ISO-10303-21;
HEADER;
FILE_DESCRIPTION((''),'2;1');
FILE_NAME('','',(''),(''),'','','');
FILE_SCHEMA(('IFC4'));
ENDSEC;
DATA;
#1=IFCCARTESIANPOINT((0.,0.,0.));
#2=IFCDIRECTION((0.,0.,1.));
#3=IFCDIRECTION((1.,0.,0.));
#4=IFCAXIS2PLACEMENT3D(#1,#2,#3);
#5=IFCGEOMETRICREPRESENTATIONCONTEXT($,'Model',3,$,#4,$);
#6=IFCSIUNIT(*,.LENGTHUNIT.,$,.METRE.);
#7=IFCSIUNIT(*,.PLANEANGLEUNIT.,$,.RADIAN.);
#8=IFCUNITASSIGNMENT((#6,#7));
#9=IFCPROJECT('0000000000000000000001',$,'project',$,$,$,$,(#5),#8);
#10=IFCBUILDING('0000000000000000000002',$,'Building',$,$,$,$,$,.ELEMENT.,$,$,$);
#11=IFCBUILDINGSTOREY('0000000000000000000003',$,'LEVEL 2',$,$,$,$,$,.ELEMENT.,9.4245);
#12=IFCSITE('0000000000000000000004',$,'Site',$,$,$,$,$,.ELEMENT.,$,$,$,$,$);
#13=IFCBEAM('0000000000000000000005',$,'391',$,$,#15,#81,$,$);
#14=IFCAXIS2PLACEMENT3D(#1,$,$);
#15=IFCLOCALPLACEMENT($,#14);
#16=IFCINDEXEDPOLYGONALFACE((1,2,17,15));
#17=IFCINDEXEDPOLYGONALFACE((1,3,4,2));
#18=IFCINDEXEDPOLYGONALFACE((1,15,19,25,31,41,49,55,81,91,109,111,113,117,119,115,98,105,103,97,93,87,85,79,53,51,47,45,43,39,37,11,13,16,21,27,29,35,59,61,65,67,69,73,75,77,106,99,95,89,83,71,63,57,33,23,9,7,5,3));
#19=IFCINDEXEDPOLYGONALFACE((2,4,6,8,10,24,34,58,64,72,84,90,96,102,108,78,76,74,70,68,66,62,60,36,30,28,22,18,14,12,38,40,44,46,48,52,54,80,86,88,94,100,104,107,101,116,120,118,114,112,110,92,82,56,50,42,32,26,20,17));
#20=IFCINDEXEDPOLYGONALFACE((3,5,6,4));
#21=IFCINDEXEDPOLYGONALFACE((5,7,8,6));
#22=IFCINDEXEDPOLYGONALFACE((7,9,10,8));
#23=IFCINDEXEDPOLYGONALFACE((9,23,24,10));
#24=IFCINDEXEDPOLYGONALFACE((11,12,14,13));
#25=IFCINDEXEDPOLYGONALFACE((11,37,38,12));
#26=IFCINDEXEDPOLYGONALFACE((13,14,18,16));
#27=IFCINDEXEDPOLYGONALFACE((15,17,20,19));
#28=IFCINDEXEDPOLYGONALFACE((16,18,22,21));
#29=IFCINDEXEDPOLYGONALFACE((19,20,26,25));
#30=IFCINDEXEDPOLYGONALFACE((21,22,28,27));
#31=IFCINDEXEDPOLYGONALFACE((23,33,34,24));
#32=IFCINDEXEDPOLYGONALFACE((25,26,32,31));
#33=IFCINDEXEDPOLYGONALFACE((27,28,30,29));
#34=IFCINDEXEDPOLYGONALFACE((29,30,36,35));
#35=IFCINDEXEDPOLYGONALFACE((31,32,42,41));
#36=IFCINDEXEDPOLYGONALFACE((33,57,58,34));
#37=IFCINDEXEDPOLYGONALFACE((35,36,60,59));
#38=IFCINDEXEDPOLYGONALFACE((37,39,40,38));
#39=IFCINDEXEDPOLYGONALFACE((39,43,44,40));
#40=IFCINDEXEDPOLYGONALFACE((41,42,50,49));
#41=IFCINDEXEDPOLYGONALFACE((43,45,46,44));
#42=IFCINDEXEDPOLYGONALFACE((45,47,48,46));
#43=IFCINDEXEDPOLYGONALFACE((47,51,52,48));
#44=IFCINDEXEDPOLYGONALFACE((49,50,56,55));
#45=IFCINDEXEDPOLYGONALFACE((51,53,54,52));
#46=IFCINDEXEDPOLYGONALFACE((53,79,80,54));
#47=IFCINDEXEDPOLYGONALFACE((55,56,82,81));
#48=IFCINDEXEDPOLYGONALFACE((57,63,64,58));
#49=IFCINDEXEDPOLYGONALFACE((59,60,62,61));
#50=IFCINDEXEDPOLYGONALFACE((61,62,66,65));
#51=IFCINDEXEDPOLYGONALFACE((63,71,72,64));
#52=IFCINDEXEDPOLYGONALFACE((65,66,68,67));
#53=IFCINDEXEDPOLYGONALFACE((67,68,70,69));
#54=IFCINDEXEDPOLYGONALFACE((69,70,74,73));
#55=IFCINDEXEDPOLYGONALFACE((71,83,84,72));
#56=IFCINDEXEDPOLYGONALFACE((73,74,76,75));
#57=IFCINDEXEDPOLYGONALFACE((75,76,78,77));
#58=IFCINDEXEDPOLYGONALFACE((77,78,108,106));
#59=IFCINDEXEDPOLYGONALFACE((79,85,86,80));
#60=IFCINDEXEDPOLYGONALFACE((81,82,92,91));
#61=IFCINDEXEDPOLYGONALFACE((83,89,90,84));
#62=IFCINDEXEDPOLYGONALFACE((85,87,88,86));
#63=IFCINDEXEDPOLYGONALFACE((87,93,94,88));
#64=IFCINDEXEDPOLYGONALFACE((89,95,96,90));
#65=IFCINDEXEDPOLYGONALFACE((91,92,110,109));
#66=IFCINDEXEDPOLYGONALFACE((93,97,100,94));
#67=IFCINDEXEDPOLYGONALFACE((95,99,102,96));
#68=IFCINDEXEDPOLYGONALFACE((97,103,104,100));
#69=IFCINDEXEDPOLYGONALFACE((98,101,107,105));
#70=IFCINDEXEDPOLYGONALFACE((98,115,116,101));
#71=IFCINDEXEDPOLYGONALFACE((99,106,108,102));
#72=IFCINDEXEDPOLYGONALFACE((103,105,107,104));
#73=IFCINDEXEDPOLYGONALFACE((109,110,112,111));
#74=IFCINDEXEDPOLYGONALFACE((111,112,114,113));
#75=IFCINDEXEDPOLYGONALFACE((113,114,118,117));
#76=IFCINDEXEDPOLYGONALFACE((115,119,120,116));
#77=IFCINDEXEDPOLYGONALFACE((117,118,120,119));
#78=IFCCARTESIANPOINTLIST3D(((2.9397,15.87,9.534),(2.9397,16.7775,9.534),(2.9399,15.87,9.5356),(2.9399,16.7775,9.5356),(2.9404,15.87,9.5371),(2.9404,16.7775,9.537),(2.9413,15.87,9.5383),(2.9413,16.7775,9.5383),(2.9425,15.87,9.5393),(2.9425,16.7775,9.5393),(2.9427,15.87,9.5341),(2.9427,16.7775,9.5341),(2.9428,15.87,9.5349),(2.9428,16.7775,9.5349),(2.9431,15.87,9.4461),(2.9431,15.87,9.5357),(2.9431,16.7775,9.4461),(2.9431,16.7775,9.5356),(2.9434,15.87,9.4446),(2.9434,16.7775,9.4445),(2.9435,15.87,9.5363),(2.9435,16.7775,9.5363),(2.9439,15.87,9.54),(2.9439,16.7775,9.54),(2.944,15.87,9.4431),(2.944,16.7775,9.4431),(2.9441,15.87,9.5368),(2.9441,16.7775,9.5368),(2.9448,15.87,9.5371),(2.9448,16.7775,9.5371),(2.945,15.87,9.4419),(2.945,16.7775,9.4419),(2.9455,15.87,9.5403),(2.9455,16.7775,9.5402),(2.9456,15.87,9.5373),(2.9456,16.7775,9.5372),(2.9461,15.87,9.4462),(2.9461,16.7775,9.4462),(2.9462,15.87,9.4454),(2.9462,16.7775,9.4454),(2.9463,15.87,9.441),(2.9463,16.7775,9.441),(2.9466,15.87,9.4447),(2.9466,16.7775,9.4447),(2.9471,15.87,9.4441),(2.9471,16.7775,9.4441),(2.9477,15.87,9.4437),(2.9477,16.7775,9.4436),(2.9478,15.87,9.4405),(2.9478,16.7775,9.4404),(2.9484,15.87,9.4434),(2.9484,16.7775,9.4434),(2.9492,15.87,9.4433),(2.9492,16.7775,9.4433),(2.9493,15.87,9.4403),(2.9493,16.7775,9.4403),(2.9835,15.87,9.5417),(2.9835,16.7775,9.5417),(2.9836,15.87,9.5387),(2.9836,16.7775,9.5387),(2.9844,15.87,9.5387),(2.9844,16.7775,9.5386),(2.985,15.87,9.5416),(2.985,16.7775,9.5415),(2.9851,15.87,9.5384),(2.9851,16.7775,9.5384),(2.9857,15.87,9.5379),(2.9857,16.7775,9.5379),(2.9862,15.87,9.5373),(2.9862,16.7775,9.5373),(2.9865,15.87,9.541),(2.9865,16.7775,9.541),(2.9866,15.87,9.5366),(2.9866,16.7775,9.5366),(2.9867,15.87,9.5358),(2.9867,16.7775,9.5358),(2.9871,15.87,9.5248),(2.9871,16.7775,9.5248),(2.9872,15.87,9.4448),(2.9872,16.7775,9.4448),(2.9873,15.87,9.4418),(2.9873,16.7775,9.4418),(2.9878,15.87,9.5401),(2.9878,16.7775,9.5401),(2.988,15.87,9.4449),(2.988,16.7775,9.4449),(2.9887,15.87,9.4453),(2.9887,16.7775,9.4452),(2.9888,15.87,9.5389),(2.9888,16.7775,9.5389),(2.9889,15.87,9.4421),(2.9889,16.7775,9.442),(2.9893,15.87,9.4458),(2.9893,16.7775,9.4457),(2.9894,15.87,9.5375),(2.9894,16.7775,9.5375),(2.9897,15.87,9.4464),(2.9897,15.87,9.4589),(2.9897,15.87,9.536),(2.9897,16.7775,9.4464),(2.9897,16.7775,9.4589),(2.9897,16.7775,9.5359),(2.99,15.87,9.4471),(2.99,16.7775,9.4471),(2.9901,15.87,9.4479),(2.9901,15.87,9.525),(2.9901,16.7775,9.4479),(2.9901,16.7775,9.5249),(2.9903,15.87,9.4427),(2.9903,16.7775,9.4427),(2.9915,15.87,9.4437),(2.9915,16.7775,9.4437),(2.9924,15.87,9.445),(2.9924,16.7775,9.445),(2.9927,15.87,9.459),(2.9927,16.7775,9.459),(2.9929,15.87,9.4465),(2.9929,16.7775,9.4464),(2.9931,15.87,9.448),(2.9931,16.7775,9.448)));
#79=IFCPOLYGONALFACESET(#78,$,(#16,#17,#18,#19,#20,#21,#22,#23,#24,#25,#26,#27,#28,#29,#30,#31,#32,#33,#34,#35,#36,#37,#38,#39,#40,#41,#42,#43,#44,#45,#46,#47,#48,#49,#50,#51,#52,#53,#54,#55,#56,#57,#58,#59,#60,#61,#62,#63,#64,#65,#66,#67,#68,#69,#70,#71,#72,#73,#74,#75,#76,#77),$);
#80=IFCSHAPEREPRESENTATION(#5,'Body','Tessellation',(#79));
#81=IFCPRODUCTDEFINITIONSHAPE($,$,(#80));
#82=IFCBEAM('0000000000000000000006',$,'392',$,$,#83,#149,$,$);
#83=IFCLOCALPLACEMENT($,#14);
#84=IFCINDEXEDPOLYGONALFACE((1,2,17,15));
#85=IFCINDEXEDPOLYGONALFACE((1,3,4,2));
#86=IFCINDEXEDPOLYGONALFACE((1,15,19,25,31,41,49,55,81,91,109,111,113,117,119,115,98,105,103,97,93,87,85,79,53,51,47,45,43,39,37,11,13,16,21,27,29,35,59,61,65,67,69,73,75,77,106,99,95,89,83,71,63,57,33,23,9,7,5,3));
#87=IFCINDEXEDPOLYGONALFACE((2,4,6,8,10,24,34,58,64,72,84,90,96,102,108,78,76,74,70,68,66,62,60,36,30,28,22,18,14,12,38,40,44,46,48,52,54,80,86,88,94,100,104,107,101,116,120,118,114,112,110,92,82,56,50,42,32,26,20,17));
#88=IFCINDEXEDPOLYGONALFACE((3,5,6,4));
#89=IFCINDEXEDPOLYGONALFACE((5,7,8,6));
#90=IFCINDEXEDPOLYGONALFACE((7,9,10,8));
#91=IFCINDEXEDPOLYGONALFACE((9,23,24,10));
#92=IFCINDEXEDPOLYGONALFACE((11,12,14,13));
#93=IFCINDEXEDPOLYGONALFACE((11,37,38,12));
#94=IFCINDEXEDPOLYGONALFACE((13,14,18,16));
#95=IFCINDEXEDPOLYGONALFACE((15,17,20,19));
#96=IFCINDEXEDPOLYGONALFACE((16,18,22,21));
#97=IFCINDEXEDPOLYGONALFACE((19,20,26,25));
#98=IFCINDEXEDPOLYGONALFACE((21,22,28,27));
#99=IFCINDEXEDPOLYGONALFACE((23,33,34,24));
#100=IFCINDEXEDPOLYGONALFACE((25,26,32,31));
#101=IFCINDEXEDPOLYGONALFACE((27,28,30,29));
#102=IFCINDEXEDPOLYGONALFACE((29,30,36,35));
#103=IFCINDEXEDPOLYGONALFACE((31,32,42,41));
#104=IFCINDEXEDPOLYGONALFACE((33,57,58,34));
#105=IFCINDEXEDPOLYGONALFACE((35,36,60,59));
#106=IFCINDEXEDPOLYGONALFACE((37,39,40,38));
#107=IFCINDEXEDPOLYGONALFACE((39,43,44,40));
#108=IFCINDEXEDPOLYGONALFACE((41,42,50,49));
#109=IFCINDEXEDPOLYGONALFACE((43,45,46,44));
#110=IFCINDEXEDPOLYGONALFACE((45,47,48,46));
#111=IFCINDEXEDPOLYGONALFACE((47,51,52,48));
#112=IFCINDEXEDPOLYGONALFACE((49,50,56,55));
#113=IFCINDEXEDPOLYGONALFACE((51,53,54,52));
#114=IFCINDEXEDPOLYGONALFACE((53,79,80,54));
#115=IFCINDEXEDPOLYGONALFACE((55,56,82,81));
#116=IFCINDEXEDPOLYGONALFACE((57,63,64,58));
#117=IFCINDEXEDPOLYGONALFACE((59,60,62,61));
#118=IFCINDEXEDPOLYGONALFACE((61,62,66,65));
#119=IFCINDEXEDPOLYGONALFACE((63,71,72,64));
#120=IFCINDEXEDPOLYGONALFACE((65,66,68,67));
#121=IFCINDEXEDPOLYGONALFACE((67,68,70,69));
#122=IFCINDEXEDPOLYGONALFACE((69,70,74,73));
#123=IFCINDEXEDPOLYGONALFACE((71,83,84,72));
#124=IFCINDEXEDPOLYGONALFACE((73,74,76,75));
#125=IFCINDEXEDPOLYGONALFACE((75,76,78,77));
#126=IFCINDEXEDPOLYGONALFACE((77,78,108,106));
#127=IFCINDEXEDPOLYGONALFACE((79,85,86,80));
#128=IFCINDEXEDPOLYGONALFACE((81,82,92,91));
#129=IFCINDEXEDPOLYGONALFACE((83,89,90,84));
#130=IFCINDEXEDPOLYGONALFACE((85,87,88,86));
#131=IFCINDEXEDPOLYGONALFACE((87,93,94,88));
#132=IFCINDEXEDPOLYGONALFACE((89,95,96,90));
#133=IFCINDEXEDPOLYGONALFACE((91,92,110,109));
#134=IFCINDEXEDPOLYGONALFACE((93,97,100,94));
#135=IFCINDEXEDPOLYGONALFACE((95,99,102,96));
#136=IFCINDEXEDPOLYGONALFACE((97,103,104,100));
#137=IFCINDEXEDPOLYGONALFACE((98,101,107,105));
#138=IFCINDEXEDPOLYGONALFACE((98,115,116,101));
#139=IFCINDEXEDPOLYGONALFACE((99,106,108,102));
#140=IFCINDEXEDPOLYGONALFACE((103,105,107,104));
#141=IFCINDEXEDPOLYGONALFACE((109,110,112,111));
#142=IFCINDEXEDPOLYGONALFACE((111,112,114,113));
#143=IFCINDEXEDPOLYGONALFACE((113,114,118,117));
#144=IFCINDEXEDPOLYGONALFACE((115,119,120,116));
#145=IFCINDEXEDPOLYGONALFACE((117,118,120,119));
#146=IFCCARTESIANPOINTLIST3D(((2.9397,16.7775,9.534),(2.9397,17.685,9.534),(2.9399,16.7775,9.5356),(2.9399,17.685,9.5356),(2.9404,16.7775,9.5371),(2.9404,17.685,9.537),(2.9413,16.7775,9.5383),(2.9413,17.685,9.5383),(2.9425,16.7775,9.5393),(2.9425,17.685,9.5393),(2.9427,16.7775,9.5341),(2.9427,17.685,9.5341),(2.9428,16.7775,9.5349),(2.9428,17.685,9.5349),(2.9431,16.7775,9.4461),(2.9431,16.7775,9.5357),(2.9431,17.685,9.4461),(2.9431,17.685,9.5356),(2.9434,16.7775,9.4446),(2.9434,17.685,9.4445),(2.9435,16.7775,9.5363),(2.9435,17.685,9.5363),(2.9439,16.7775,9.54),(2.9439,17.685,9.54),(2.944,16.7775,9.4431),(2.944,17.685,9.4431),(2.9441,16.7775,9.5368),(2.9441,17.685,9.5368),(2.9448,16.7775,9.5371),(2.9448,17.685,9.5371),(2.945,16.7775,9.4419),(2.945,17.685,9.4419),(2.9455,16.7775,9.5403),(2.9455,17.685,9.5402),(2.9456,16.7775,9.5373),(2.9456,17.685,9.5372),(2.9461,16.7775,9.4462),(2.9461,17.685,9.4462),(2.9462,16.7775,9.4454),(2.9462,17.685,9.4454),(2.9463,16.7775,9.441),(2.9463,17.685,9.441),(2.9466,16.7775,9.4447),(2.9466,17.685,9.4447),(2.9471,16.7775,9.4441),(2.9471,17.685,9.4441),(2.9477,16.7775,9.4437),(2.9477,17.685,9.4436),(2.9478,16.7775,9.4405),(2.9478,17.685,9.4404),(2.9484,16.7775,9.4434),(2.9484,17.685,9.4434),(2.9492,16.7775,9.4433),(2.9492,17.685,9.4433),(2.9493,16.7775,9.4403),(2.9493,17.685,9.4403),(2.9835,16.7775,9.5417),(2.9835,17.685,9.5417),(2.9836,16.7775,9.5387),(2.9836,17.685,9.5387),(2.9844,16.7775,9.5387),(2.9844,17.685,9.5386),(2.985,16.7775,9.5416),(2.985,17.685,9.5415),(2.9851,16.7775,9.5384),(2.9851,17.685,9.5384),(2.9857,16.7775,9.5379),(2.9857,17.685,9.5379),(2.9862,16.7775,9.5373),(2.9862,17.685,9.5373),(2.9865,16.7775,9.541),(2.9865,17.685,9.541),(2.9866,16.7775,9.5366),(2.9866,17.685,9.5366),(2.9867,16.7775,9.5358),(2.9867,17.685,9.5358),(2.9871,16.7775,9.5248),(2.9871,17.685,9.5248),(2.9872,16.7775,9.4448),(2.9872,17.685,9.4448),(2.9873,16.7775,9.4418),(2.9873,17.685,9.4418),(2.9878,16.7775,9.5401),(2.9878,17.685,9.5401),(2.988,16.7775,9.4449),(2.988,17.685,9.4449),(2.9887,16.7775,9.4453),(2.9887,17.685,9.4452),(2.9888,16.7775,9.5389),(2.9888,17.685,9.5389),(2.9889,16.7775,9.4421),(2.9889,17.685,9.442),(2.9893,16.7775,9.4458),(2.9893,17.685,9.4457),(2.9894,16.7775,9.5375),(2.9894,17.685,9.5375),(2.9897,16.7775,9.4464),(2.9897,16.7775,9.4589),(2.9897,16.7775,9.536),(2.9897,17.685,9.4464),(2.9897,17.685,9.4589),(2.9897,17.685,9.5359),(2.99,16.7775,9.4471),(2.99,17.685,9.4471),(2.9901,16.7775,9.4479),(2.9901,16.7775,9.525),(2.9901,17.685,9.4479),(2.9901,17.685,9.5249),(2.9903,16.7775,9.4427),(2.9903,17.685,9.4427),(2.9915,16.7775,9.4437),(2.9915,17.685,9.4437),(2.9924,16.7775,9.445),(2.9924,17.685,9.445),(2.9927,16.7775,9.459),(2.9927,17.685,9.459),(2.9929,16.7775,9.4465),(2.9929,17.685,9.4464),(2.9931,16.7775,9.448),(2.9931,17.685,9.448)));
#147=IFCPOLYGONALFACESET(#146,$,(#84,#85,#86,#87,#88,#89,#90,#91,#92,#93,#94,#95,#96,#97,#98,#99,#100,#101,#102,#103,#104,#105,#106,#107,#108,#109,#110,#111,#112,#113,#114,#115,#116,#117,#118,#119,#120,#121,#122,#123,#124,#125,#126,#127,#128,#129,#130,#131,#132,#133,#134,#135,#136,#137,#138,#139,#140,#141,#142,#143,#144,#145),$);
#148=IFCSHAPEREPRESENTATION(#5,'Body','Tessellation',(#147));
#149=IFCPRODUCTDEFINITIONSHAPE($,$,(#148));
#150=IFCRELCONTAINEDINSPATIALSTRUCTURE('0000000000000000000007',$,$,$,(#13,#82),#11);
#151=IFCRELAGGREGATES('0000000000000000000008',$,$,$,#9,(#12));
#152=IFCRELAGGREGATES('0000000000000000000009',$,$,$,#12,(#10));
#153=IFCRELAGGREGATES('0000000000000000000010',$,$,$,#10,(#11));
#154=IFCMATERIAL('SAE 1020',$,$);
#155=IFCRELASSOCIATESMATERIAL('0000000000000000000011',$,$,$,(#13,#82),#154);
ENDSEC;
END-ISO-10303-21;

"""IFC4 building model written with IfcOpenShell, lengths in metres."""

from ifc_helpers import new_model, si_unit, frame, origin_with_axes, origin_2d_with_axis, place, context, project, spatial, c_section, extrude, material, material_profile, profile_set, profile_usage, element, save


model = new_model("IFC4")

# Units and contexts
model_context = context("Model", 3, world=origin_with_axes())
ifc_project = project(units=[si_unit("LENGTHUNIT", "METRE"), si_unit("PLANEANGLEUNIT", "RADIAN")], contexts=[model_context])

# Site, building, storey
site = spatial("IfcSite", under=ifc_project, Name="Site", CompositionType="ELEMENT")
building = spatial("IfcBuilding", under=site, Name="Building", CompositionType="ELEMENT")
storey = spatial("IfcBuildingStorey", under=building, Name="LEVEL 2", CompositionType="ELEMENT", Elevation=9.4245)

# Beams
ifc_material = material(Name="SAE 1020")
ifc_material_profile_1 = material_profile(ifc_material, c_section(Depth=0.1, Width=0.05, WallThickness=0.003, Girth=0.017, InternalFilletRadius=0.003, at=origin_2d_with_axis()))
ifc_profile_set_1 = profile_set([ifc_material_profile_1])
ifc_profile_usage_1 = profile_usage(ifc_profile_set_1, cardinal=10)
beam_1_placement = place(None, frame((2.9664, 15.87, 9.491), z_axis=(0.0, 1.0, -0.00003), x_axis=(0.999256, 0.000001, 0.038562)))
element("IfcBeam", 1, at=beam_1_placement, inside=storey, material=ifc_profile_usage_1, Name="391", context=model_context, shape_type="SweptSolid", body=[
    extrude(c_section(Depth=0.1, Width=0.05, WallThickness=0.003, Girth=0.017, InternalFilletRadius=0.003, at=origin_2d_with_axis()), origin_with_axes(), (0.0, 0.0, 1.0), 0.9075),
])
ifc_material_profile_2 = material_profile(ifc_material, c_section(Depth=0.1, Width=0.05, WallThickness=0.003, Girth=0.017, InternalFilletRadius=0.003, at=origin_2d_with_axis()))
ifc_profile_set_2 = profile_set([ifc_material_profile_2])
ifc_profile_usage_2 = profile_usage(ifc_profile_set_2, cardinal=10)
beam_2_placement = place(None, frame((2.9664, 16.7775, 9.491), z_axis=(0.0, 1.0, -0.00003), x_axis=(0.999256, 0.000001, 0.038562)))
element("IfcBeam", 2, at=beam_2_placement, inside=storey, material=ifc_profile_usage_2, Name="392", context=model_context, shape_type="SweptSolid", body=[
    extrude(c_section(Depth=0.1, Width=0.05, WallThickness=0.003, Girth=0.017, InternalFilletRadius=0.003, at=origin_2d_with_axis()), origin_with_axes(), (0.0, 0.0, 1.0), 0.9075),
])

save(model, "model.ifc")
